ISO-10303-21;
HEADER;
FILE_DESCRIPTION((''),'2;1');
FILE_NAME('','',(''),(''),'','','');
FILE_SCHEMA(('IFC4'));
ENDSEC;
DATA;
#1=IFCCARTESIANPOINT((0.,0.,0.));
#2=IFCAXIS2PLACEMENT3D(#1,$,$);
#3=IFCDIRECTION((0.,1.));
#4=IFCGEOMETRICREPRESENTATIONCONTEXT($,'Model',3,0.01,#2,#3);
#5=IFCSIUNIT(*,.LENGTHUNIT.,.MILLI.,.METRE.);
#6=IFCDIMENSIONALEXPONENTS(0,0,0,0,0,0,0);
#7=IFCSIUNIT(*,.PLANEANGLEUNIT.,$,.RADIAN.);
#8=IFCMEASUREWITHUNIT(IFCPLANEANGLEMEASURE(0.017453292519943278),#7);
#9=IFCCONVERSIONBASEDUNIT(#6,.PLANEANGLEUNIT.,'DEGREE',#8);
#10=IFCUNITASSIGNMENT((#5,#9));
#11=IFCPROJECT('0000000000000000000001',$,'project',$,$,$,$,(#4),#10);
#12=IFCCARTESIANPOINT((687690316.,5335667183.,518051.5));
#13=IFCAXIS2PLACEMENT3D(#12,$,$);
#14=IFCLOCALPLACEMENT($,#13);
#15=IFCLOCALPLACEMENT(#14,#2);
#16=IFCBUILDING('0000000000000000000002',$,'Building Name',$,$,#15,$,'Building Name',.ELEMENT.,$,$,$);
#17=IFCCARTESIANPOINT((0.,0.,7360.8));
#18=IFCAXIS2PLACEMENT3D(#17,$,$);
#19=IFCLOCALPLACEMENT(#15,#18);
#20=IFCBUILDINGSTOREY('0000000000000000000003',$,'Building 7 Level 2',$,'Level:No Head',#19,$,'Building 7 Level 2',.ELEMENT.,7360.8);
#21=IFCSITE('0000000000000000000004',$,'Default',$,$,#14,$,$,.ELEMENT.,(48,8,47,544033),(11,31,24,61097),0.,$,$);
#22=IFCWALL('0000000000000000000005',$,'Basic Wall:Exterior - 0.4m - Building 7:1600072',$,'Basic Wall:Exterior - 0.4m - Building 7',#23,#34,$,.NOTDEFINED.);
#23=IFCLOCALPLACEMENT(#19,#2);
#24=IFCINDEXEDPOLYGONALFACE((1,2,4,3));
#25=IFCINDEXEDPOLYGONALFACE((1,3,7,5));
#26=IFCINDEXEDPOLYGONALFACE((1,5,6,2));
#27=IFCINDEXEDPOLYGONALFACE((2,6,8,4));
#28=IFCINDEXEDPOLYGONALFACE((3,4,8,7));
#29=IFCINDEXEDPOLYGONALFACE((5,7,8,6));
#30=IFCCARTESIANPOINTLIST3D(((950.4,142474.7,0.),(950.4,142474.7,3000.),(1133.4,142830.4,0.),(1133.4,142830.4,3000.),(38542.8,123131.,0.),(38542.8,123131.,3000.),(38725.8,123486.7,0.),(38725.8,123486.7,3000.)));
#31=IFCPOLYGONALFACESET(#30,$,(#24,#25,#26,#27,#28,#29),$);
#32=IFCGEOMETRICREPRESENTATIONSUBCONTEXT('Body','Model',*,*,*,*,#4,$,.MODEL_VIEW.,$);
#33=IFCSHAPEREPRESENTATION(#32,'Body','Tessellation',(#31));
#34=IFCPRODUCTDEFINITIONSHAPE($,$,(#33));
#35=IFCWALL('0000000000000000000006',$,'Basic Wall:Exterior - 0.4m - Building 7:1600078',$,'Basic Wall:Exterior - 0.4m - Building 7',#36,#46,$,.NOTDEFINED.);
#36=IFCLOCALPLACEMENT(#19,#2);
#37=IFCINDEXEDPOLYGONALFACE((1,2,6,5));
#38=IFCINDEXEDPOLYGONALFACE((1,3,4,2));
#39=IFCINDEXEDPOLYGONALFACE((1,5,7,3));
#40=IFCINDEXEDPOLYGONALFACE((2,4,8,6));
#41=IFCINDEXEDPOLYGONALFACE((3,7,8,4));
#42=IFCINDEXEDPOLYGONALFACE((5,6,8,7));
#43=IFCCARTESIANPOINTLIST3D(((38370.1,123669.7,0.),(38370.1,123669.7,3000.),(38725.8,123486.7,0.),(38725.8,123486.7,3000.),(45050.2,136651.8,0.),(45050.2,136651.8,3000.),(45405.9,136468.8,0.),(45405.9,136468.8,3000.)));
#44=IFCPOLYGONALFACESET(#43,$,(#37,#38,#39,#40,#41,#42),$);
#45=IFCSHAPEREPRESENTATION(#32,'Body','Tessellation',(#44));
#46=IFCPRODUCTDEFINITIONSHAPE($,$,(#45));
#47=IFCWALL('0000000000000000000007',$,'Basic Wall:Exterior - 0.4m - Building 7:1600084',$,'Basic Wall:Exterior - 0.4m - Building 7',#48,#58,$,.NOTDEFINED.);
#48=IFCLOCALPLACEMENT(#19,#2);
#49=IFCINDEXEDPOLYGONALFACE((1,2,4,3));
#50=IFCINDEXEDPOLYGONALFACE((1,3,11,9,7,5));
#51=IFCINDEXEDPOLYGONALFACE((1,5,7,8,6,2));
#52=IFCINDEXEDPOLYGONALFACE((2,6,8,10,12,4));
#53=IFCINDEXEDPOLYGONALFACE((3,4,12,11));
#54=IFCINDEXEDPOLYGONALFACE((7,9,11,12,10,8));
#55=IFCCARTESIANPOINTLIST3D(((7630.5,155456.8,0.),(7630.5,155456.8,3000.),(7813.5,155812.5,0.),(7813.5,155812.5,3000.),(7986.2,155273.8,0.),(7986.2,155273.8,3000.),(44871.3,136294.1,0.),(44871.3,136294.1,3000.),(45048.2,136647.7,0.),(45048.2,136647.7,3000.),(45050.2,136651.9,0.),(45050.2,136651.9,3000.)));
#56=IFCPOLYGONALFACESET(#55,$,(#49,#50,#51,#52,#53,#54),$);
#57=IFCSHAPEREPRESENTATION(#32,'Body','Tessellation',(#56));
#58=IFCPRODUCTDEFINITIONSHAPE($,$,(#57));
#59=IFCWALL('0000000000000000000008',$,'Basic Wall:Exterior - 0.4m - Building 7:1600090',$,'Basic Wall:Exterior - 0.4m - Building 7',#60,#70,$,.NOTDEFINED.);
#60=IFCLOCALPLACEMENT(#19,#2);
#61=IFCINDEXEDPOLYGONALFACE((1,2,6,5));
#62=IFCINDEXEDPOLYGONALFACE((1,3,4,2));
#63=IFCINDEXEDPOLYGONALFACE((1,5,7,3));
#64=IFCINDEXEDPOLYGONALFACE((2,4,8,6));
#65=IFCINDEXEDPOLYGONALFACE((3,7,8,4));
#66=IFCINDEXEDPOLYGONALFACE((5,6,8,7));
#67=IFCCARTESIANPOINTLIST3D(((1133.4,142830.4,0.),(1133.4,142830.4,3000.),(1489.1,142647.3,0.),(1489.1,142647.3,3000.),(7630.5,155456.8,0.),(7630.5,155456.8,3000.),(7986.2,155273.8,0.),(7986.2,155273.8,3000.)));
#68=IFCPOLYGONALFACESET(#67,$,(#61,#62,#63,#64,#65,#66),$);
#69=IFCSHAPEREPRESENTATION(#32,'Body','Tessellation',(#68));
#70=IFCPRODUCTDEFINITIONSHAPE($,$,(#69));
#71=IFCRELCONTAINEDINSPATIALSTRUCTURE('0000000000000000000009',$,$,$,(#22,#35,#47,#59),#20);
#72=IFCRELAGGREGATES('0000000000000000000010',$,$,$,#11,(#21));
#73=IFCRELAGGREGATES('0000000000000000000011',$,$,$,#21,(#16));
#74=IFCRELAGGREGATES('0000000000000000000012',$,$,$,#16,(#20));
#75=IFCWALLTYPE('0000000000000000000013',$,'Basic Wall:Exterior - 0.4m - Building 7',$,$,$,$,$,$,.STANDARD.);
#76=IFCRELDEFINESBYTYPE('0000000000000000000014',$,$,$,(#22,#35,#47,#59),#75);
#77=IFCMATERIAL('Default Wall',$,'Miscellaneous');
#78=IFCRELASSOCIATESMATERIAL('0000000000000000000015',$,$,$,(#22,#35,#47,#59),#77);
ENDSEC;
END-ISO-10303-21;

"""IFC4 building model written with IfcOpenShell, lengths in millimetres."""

from ifc_helpers import new_model, entity, si_unit, converted_unit, direction, frame, origin, place, context, subcontext, project, spatial, indexed_curve, outline, extrude, material, type_object, element, save


model = new_model("IFC4")

# Units and contexts
model_context = context("Model", 3, precision=0.01, world=origin(), true_north=direction((0.0, 1.0)))
body_context = subcontext(model_context, "Body", "Model", "MODEL_VIEW")
ifc_project = project(units=[si_unit("LENGTHUNIT", "METRE", prefix="MILLI"), converted_unit("PLANEANGLEUNIT", "DEGREE", entity("IfcPlaneAngleMeasure", 0.017453292519943278), si_unit("PLANEANGLEUNIT", "RADIAN"), dimensions=[0, 0, 0, 0, 0, 0, 0])], contexts=[model_context])

# Site, building, storey
site_placement = place(None, frame((687690316.0, 5335667183.0, 518051.5)))
site = spatial("IfcSite", under=ifc_project, at=site_placement, Name="Default", CompositionType="ELEMENT", RefLatitude=(48, 8, 47, 544033), RefLongitude=(11, 31, 24, 61097), RefElevation=0.0)
building_placement = place(site_placement, origin())
building = spatial("IfcBuilding", under=site, at=building_placement, Name="Building Name", LongName="Building Name", CompositionType="ELEMENT")
storey_placement = place(building_placement, frame((0.0, 0.0, 7360.8)))
storey = spatial("IfcBuildingStorey", under=building, at=storey_placement, Name="Building 7 Level 2", ObjectType="Level:No Head", LongName="Building 7 Level 2", CompositionType="ELEMENT", Elevation=7360.8)

# Walls
ifc_material_1 = material(Name="Default Wall", Category="Miscellaneous")
wall_type = type_object("IfcWallType", Name="Basic Wall:Exterior - 0.4m - Building 7", PredefinedType="STANDARD")
wall_1_placement = place(storey_placement, frame((1041.9, 142652.5, 0.0), z_axis=(0.0, 0.0, 1.0), x_axis=(0.889187, -0.457543, 0.0)))
element("IfcWall", 1, at=wall_1_placement, inside=storey, type_object=wall_type, material=ifc_material_1, Name="Basic Wall:Exterior - 0.4m - Building 7:1600072", ObjectType="Basic Wall:Exterior - 0.4m - Building 7", PredefinedType="NOTDEFINED", context=body_context, shape_type="SweptSolid", body=[
    extrude(outline(indexed_curve([(42277.2, 200.0), (0.0, 200.0), (0.0, -200.0), (42277.2, -200.0), (42277.2, 200.0)], self_intersect=False)), origin(), (0.0, 0.0, 1.0), 3000.0),
])
wall_2_placement = place(storey_placement, frame((38548.0, 123578.2, 0.0), z_axis=(0.0, 0.0, 1.0), x_axis=(0.457543, 0.889187, 0.0)))
element("IfcWall", 2, at=wall_2_placement, inside=storey, type_object=wall_type, material=ifc_material_1, Name="Basic Wall:Exterior - 0.4m - Building 7:1600078", ObjectType="Basic Wall:Exterior - 0.4m - Building 7", PredefinedType="NOTDEFINED", context=body_context, shape_type="SweptSolid", body=[
    extrude(outline(indexed_curve([(14600.0, 200.0), (0.0, 200.0), (0.0, -200.0), (14600.0, -200.0), (14600.0, 200.0)], self_intersect=False)), origin(), (0.0, 0.0, 1.0), 3000.0),
])
wall_3_placement = place(storey_placement, frame((44962.8, 136471.9, 0.0), z_axis=(0.0, 0.0, 1.0), x_axis=(-0.889187, 0.457543, 0.0)))
element("IfcWall", 3, at=wall_3_placement, inside=storey, type_object=wall_type, material=ifc_material_1, Name="Basic Wall:Exterior - 0.4m - Building 7:1600084", ObjectType="Basic Wall:Exterior - 0.4m - Building 7", PredefinedType="NOTDEFINED", context=body_context, shape_type="SweptSolid", body=[
    extrude(outline(indexed_curve([(41881.8, -200.0), (41881.8, 200.0), (41481.8, 200.0), (0.0, 200.0), (4.6, -195.4), (4.6, -200.0), (41881.8, -200.0)], self_intersect=False)), origin(), (0.0, 0.0, 1.0), 3000.0),
])
wall_4_placement = place(storey_placement, frame((7808.3, 155365.3, 0.0), z_axis=(0.0, 0.0, 1.0), x_axis=(-0.457543, -0.889187, 0.0)))
element("IfcWall", 4, at=wall_4_placement, inside=storey, type_object=wall_type, material=ifc_material_1, Name="Basic Wall:Exterior - 0.4m - Building 7:1600090", ObjectType="Basic Wall:Exterior - 0.4m - Building 7", PredefinedType="NOTDEFINED", context=body_context, shape_type="SweptSolid", body=[
    extrude(outline(indexed_curve([(14200.0, 200.0), (0.0, 200.0), (0.0, -200.0), (14200.0, -200.0), (14200.0, 200.0)], self_intersect=False)), origin(), (0.0, 0.0, 1.0), 3000.0),
])

save(model, "model.ifc")
